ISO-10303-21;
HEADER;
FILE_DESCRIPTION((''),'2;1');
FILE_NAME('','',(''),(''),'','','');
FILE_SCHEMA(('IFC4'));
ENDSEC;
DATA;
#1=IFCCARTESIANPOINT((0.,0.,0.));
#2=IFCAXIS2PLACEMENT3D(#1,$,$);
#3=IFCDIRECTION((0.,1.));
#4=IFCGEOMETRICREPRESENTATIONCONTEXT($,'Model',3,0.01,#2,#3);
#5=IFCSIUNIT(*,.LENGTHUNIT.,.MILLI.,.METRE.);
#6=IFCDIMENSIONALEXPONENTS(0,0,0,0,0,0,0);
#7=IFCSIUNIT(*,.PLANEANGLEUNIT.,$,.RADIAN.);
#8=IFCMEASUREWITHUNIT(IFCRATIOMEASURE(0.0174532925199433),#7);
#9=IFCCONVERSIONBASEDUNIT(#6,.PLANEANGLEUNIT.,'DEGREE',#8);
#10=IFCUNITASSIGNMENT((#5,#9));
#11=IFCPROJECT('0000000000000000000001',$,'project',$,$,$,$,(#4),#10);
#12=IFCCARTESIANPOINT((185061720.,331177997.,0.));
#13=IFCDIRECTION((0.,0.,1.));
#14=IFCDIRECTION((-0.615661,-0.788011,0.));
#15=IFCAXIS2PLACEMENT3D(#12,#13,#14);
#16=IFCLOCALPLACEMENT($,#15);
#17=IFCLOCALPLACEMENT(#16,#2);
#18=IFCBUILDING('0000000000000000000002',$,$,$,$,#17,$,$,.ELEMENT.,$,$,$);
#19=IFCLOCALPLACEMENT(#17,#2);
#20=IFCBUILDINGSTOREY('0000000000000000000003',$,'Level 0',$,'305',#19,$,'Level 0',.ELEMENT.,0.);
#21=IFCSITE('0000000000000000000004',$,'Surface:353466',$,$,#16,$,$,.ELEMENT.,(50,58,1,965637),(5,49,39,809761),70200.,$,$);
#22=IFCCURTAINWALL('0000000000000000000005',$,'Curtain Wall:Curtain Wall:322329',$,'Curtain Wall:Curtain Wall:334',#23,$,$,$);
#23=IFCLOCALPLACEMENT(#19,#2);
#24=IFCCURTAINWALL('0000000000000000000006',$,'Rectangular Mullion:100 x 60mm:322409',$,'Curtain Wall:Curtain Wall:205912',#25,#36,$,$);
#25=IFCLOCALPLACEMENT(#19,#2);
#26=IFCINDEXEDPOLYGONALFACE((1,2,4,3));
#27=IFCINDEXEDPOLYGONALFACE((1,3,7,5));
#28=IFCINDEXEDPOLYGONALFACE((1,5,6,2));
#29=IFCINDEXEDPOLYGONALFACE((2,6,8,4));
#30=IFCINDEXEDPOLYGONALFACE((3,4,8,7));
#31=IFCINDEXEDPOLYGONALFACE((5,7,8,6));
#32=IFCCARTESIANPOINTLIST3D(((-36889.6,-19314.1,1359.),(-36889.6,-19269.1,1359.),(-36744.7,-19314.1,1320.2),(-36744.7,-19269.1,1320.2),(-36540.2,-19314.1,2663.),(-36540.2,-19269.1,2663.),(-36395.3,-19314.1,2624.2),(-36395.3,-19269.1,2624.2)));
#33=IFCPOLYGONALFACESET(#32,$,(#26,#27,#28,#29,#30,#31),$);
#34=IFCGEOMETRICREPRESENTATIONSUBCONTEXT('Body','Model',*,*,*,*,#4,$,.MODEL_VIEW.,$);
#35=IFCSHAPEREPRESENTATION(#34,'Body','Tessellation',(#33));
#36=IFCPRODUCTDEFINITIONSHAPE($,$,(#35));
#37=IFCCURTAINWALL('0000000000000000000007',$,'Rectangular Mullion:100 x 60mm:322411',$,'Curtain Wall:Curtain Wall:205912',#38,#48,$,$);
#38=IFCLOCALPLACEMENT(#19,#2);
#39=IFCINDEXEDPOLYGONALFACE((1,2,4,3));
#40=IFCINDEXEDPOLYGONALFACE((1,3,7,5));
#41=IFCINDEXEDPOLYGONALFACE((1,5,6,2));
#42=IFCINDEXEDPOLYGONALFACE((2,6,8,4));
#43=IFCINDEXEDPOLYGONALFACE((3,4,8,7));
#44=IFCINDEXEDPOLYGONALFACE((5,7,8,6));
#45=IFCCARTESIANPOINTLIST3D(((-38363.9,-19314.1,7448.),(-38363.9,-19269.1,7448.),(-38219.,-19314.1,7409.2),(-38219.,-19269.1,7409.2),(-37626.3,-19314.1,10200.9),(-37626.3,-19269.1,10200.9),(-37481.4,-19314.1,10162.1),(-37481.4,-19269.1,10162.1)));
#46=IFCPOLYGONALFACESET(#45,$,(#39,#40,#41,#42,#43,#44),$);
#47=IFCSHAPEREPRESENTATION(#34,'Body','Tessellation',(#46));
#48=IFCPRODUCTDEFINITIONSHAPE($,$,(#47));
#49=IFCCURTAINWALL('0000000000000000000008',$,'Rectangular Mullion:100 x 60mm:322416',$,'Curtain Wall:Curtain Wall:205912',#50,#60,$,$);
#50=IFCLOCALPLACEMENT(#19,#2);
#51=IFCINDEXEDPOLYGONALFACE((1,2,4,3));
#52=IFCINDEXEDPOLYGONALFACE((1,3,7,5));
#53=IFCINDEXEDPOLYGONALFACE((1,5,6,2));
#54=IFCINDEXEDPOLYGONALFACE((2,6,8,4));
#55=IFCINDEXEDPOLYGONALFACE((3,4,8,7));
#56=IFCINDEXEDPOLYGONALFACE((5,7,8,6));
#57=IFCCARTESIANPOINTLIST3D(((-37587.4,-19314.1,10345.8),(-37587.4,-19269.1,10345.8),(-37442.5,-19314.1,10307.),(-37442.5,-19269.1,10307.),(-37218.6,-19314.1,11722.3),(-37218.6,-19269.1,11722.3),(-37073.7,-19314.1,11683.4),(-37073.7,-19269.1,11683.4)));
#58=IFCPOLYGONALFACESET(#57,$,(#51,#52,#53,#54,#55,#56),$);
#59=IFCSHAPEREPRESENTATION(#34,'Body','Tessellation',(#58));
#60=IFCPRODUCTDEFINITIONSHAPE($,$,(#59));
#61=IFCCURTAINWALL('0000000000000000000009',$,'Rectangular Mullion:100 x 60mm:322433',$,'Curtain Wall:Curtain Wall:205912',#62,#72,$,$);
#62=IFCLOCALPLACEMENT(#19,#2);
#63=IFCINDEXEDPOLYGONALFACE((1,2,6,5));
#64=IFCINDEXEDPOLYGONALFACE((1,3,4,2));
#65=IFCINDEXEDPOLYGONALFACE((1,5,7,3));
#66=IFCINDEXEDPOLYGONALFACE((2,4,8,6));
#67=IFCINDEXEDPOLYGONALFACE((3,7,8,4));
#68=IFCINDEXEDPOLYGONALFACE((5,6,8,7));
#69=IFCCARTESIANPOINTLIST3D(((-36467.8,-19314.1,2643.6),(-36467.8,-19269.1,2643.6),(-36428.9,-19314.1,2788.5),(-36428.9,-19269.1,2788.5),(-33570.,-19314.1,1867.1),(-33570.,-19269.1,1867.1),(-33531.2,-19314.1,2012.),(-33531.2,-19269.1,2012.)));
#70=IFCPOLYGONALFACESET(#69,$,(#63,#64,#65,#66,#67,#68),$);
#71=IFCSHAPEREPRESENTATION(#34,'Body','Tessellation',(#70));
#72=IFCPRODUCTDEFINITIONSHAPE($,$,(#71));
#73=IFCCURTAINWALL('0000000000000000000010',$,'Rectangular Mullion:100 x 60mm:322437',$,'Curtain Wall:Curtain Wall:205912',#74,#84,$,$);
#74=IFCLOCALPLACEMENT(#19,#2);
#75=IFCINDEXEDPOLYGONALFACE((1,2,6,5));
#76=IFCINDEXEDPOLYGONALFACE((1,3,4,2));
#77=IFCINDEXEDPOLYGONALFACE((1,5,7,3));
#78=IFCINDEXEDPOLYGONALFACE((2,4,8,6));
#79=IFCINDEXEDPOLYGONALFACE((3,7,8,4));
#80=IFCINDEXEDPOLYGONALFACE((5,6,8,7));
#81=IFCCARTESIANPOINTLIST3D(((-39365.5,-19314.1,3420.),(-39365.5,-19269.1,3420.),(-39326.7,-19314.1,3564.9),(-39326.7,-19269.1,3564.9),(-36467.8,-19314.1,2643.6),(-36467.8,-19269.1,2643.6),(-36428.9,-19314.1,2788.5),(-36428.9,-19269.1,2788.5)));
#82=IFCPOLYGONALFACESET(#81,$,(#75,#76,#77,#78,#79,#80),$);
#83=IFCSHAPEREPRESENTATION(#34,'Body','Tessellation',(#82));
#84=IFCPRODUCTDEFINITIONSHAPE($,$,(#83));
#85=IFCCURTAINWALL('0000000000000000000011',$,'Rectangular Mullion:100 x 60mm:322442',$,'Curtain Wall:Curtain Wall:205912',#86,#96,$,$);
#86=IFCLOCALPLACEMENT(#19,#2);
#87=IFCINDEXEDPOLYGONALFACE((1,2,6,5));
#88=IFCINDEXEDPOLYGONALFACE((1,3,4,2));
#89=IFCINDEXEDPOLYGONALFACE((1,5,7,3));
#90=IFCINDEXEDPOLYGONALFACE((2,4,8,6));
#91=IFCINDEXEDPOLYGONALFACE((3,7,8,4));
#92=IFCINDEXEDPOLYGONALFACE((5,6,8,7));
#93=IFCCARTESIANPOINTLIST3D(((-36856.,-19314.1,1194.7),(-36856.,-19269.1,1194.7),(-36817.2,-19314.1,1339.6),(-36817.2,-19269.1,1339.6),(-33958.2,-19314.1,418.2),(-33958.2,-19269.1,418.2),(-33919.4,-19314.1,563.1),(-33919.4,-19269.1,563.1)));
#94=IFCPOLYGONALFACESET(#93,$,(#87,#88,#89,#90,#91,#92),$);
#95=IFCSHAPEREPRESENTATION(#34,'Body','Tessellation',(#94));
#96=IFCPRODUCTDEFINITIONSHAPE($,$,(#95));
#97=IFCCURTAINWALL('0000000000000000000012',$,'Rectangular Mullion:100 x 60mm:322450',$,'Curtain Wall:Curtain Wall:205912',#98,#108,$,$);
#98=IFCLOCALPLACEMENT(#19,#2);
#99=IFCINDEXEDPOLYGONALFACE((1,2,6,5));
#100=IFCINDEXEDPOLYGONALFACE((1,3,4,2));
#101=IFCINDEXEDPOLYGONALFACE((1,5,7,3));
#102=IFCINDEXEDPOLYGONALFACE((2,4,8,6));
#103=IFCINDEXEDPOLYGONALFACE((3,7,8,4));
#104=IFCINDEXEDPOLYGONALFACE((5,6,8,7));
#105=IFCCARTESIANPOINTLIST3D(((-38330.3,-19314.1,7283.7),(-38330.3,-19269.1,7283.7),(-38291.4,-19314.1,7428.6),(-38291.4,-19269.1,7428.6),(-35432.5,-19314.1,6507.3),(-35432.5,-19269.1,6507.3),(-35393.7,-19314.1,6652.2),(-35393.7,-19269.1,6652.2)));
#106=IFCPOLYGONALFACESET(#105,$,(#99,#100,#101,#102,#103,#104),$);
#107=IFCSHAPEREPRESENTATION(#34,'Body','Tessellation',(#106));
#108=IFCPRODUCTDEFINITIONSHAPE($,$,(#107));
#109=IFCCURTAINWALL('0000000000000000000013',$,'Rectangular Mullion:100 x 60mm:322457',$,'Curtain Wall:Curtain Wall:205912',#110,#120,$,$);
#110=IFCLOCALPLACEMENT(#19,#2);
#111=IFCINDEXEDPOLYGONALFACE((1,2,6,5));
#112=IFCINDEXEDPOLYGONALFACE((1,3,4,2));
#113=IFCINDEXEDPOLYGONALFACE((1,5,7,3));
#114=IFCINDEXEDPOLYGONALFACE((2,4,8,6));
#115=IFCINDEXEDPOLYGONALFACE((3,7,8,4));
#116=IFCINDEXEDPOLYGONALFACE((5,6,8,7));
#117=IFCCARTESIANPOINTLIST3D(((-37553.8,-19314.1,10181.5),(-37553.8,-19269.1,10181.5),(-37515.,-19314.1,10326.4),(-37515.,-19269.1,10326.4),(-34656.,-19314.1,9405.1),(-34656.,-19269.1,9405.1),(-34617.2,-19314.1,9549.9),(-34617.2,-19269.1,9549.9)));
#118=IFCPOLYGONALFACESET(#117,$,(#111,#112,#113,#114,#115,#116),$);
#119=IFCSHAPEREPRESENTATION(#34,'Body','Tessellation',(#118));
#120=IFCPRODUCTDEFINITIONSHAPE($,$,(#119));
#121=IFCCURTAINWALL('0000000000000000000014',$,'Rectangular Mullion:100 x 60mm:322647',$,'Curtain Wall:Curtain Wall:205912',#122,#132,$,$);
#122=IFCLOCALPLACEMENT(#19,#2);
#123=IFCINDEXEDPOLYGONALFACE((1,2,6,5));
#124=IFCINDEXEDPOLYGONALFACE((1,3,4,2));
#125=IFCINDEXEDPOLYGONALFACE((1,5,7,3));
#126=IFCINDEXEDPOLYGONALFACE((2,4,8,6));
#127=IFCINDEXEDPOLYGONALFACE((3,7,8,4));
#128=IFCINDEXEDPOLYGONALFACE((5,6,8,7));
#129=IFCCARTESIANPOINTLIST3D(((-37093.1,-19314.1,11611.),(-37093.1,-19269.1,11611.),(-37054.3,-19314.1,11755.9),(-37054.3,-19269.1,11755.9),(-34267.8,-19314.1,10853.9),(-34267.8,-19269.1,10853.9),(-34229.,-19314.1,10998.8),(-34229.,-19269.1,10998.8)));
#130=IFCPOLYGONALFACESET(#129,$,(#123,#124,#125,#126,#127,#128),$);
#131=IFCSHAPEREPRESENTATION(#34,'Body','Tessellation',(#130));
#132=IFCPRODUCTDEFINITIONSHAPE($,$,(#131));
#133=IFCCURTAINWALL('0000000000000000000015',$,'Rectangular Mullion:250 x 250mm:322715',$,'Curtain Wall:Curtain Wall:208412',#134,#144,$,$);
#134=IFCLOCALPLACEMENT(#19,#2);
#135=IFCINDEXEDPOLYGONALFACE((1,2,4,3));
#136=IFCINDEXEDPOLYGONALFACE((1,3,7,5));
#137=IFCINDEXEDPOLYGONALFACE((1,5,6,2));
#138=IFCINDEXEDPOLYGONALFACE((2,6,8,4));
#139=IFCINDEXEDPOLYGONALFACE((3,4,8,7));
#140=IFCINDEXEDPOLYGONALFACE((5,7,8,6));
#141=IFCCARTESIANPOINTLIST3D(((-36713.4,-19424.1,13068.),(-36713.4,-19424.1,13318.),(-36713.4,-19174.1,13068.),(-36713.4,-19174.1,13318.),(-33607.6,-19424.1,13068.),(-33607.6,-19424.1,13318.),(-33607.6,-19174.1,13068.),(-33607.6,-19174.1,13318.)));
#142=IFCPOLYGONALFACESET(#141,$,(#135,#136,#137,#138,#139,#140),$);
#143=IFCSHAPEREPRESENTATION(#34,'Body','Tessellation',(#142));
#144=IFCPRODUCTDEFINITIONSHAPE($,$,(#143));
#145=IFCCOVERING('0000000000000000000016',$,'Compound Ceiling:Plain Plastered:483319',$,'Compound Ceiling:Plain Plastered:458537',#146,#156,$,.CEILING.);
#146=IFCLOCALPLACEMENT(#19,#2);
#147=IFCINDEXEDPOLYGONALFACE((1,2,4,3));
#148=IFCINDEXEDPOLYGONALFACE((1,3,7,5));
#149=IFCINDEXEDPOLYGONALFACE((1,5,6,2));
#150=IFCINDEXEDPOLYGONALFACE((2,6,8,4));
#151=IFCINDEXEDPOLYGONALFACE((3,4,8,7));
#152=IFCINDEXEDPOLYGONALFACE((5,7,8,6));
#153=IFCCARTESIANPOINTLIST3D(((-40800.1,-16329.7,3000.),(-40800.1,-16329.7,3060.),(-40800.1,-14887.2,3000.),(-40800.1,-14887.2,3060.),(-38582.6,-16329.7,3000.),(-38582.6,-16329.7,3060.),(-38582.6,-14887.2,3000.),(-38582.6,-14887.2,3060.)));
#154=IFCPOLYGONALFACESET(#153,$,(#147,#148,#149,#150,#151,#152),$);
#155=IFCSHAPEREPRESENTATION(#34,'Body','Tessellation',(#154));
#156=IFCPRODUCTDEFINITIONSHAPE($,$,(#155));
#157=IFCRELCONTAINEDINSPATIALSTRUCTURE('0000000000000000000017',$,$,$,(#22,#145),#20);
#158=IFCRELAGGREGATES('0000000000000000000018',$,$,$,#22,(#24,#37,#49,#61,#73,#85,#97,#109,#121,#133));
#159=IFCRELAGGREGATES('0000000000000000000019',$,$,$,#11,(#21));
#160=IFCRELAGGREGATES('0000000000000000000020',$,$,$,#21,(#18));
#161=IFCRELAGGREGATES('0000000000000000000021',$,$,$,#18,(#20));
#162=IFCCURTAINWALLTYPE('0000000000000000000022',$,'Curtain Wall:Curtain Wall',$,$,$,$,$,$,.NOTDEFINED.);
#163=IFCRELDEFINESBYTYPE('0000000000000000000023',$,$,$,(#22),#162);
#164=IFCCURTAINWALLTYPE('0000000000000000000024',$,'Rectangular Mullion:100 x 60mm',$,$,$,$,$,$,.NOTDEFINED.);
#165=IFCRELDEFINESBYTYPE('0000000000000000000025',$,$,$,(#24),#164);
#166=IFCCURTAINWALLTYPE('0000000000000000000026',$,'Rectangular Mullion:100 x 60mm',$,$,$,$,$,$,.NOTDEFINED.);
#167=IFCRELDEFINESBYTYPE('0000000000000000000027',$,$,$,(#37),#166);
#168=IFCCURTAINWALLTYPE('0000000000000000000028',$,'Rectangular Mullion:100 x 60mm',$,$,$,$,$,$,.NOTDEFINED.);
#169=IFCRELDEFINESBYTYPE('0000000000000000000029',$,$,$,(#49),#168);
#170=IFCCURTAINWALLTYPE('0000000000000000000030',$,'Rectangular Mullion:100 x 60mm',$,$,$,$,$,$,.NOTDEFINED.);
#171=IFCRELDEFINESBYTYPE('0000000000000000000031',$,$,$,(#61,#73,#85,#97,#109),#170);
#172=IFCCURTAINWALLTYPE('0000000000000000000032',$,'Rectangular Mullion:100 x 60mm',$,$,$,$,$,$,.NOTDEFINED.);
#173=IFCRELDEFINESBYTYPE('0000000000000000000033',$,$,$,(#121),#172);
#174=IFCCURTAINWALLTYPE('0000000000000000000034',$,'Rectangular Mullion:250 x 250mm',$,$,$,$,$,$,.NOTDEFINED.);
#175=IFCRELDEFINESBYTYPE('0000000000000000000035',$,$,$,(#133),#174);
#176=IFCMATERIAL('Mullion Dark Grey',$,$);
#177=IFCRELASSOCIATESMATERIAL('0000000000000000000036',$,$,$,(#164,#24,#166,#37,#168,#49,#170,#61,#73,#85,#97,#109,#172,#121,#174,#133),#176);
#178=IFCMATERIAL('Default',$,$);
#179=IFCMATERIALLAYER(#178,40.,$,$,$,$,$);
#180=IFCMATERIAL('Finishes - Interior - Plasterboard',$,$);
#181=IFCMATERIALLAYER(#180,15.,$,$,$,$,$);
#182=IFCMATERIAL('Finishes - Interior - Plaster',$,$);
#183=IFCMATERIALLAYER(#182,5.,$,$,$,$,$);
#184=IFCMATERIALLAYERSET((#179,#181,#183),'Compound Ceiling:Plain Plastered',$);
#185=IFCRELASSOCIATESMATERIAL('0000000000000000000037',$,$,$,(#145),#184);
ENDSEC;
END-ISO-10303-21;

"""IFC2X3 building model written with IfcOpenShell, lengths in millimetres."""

from ifc_helpers import new_model, entity, si_unit, converted_unit, direction, frame, frame_2d, origin, origin_2d_with_axis, place, context, subcontext, project, spatial, rectangle, extrude, source, transform, mapped, material, layer, layer_set, layer_usage, type_object, type_shapes, element, aggregate, save


model = new_model("IFC2X3")

# Units and contexts
model_context = context("Model", 3, precision=0.01, world=origin(), true_north=direction((0.0, 1.0)))
body_context = subcontext(model_context, "Body", "Model", "MODEL_VIEW")
ifc_project = project(units=[si_unit("LENGTHUNIT", "METRE", prefix="MILLI"), converted_unit("PLANEANGLEUNIT", "DEGREE", entity("IfcRatioMeasure", 0.0174532925199433), si_unit("PLANEANGLEUNIT", "RADIAN"), dimensions=[0, 0, 0, 0, 0, 0, 0])], contexts=[model_context])

# Site, building, storey
site_placement = place(None, frame((185061720.0, 331177997.0, 0.0), z_axis=(0.0, 0.0, 1.0), x_axis=(-0.615661, -0.788011, 0.0)))
site = spatial("IfcSite", under=ifc_project, at=site_placement, Name="Surface:353466", CompositionType="ELEMENT", RefLatitude=(50, 58, 1, 965637), RefLongitude=(5, 49, 39, 809761), RefElevation=70200.0)
building_placement = place(site_placement, origin())
building = spatial("IfcBuilding", under=site, at=building_placement, CompositionType="ELEMENT")
storey_placement = place(building_placement, origin())
storey = spatial("IfcBuildingStorey", under=building, at=storey_placement, Name="Level 0", ObjectType="305", LongName="Level 0", CompositionType="ELEMENT", Elevation=0.0)

# Shared definitions
ifc_material_1 = material(Name="Finishes - Interior - Plasterboard")

# Curtain walls
curtain_wall_type_1 = type_object("IfcCurtainWallType", Name="Curtain Wall:Curtain Wall", PredefinedType="NOTDEFINED")
curtain_wall_1_placement = place(storey_placement, origin())
curtain_wall_1 = element("IfcCurtainWall", 1, at=curtain_wall_1_placement, inside=storey, type_object=curtain_wall_type_1, Name="Curtain Wall:Curtain Wall:322329", ObjectType="Curtain Wall:Curtain Wall:334")
ifc_material_2 = material(Name="Mullion Dark Grey")
curtain_wall_type_2 = type_object("IfcCurtainWallType", Name="Rectangular Mullion:100 x 60mm", PredefinedType="NOTDEFINED", material=ifc_material_2)
shared_shape_1 = source(origin(), body_context, "Body", "SweptSolid", [
    extrude(rectangle(XDim=45.0, YDim=150.0, at=frame_2d((0.0, 0.0), x_axis=(1.0, 0.0))), frame((0.0, 7.5, -1350.0), z_axis=(0.0, 0.0, 1.0), x_axis=(0.0, -1.0, 0.0)), (0.0, 0.0, 1.0), 1350.0),
])
type_shapes(curtain_wall_type_2, [shared_shape_1])
curtain_wall_2_placement = place(storey_placement, frame((-36817.2, -19299.1, 1339.6), z_axis=(-0.258819, 0.0, -0.965926), x_axis=(-0.965926, 0.0, 0.258819)))
curtain_wall_2 = element("IfcCurtainWall", 2, at=curtain_wall_2_placement, type_object=curtain_wall_type_2, material=ifc_material_2, Name="Rectangular Mullion:100 x 60mm:322409", ObjectType="Curtain Wall:Curtain Wall:205912", context=body_context, shape_type="MappedRepresentation", body=[
    mapped(shared_shape_1, transform((0.0, 0.0, 0.0), scale=1.0)),
])
curtain_wall_type_3 = type_object("IfcCurtainWallType", Name="Rectangular Mullion:100 x 60mm", PredefinedType="NOTDEFINED", material=ifc_material_2)
shared_shape_2 = source(origin(), body_context, "Body", "SweptSolid", [
    extrude(rectangle(XDim=45.0, YDim=150.0, at=frame_2d((0.0, 0.0), x_axis=(1.0, 0.0))), frame((0.0, 7.5, -2850.0), z_axis=(0.0, 0.0, 1.0), x_axis=(0.0, -1.0, 0.0)), (0.0, 0.0, 1.0), 2850.0),
])
type_shapes(curtain_wall_type_3, [shared_shape_2])
curtain_wall_3_placement = place(storey_placement, frame((-38291.4, -19299.1, 7428.6), z_axis=(-0.258819, 0.0, -0.965926), x_axis=(-0.965926, 0.0, 0.258819)))
curtain_wall_3 = element("IfcCurtainWall", 3, at=curtain_wall_3_placement, type_object=curtain_wall_type_3, material=ifc_material_2, Name="Rectangular Mullion:100 x 60mm:322411", ObjectType="Curtain Wall:Curtain Wall:205912", context=body_context, shape_type="MappedRepresentation", body=[
    mapped(shared_shape_2, transform((0.0, 0.0, 0.0), scale=1.0)),
])
curtain_wall_type_4 = type_object("IfcCurtainWallType", Name="Rectangular Mullion:100 x 60mm", PredefinedType="NOTDEFINED", material=ifc_material_2)
shared_shape_3 = source(origin(), body_context, "Body", "SweptSolid", [
    extrude(rectangle(XDim=45.0, YDim=150.0, at=frame_2d((0.0, 0.0), x_axis=(1.0, 0.0))), frame((0.0, 7.5, -1425.0), z_axis=(0.0, 0.0, 1.0), x_axis=(0.0, -1.0, 0.0)), (0.0, 0.0, 1.0), 1425.0),
])
type_shapes(curtain_wall_type_4, [shared_shape_3])
curtain_wall_4_placement = place(storey_placement, frame((-37515.0, -19299.1, 10326.4), z_axis=(-0.258819, 0.0, -0.965926), x_axis=(-0.965926, 0.0, 0.258819)))
curtain_wall_4 = element("IfcCurtainWall", 4, at=curtain_wall_4_placement, type_object=curtain_wall_type_4, material=ifc_material_2, Name="Rectangular Mullion:100 x 60mm:322416", ObjectType="Curtain Wall:Curtain Wall:205912", context=body_context, shape_type="MappedRepresentation", body=[
    mapped(shared_shape_3, transform((0.0, 0.0, 0.0), scale=1.0)),
])
curtain_wall_type_5 = type_object("IfcCurtainWallType", Name="Rectangular Mullion:100 x 60mm", PredefinedType="NOTDEFINED", material=ifc_material_2)
shared_shape_4 = source(origin(), body_context, "Body", "SweptSolid", [
    extrude(rectangle(XDim=45.0, YDim=150.0, at=frame_2d((0.0, 0.0), x_axis=(1.0, 0.0))), frame((0.0, 7.5, -3000.0), z_axis=(0.0, 0.0, 1.0), x_axis=(0.0, -1.0, 0.0)), (0.0, 0.0, 1.0), 3000.0),
])
type_shapes(curtain_wall_type_5, [shared_shape_4])
curtain_wall_5_placement = place(storey_placement, frame((-36448.4, -19299.1, 2716.0), z_axis=(-0.965926, 0.0, 0.258819), x_axis=(0.258819, 0.0, 0.965926)))
curtain_wall_5 = element("IfcCurtainWall", 5, at=curtain_wall_5_placement, type_object=curtain_wall_type_5, material=ifc_material_2, Name="Rectangular Mullion:100 x 60mm:322433", ObjectType="Curtain Wall:Curtain Wall:205912", context=body_context, shape_type="MappedRepresentation", body=[
    mapped(shared_shape_4, transform((0.0, 0.0, 0.0), scale=1.0)),
])
curtain_wall_6_placement = place(storey_placement, frame((-39346.1, -19299.1, 3492.5), z_axis=(-0.965926, 0.0, 0.258819), x_axis=(0.258819, 0.0, 0.965926)))
curtain_wall_6 = element("IfcCurtainWall", 6, at=curtain_wall_6_placement, type_object=curtain_wall_type_5, material=ifc_material_2, Name="Rectangular Mullion:100 x 60mm:322437", ObjectType="Curtain Wall:Curtain Wall:205912", context=body_context, shape_type="MappedRepresentation", body=[
    mapped(shared_shape_4, transform((0.0, 0.0, 0.0), scale=1.0)),
])
curtain_wall_7_placement = place(storey_placement, frame((-36836.6, -19299.1, 1267.1), z_axis=(-0.965926, 0.0, 0.258819), x_axis=(0.258819, 0.0, 0.965926)))
curtain_wall_7 = element("IfcCurtainWall", 7, at=curtain_wall_7_placement, type_object=curtain_wall_type_5, material=ifc_material_2, Name="Rectangular Mullion:100 x 60mm:322442", ObjectType="Curtain Wall:Curtain Wall:205912", context=body_context, shape_type="MappedRepresentation", body=[
    mapped(shared_shape_4, transform((0.0, 0.0, 0.0), scale=1.0)),
])
curtain_wall_8_placement = place(storey_placement, frame((-38310.9, -19299.1, 7356.2), z_axis=(-0.965926, 0.0, 0.258819), x_axis=(0.258819, 0.0, 0.965926)))
curtain_wall_8 = element("IfcCurtainWall", 8, at=curtain_wall_8_placement, type_object=curtain_wall_type_5, material=ifc_material_2, Name="Rectangular Mullion:100 x 60mm:322450", ObjectType="Curtain Wall:Curtain Wall:205912", context=body_context, shape_type="MappedRepresentation", body=[
    mapped(shared_shape_4, transform((0.0, 0.0, 0.0), scale=1.0)),
])
curtain_wall_9_placement = place(storey_placement, frame((-37534.4, -19299.1, 10254.0), z_axis=(-0.965926, 0.0, 0.258819), x_axis=(0.258819, 0.0, 0.965926)))
curtain_wall_9 = element("IfcCurtainWall", 9, at=curtain_wall_9_placement, type_object=curtain_wall_type_5, material=ifc_material_2, Name="Rectangular Mullion:100 x 60mm:322457", ObjectType="Curtain Wall:Curtain Wall:205912", context=body_context, shape_type="MappedRepresentation", body=[
    mapped(shared_shape_4, transform((0.0, 0.0, 0.0), scale=1.0)),
])
curtain_wall_type_6 = type_object("IfcCurtainWallType", Name="Rectangular Mullion:100 x 60mm", PredefinedType="NOTDEFINED", material=ifc_material_2)
shared_shape_5 = source(origin(), body_context, "Body", "SweptSolid", [
    extrude(rectangle(XDim=45.0, YDim=150.0, at=frame_2d((0.0, 0.0), x_axis=(1.0, 0.0))), frame((0.0, 7.5, -2925.0), z_axis=(0.0, 0.0, 1.0), x_axis=(0.0, -1.0, 0.0)), (0.0, 0.0, 1.0), 2925.0),
])
type_shapes(curtain_wall_type_6, [shared_shape_5])
curtain_wall_10_placement = place(storey_placement, frame((-37073.7, -19299.1, 11683.4), z_axis=(-0.965926, 0.0, 0.258819), x_axis=(0.258819, 0.0, 0.965926)))
curtain_wall_10 = element("IfcCurtainWall", 10, at=curtain_wall_10_placement, type_object=curtain_wall_type_6, material=ifc_material_2, Name="Rectangular Mullion:100 x 60mm:322647", ObjectType="Curtain Wall:Curtain Wall:205912", context=body_context, shape_type="MappedRepresentation", body=[
    mapped(shared_shape_5, transform((0.0, 0.0, 0.0), scale=1.0)),
])
curtain_wall_type_7 = type_object("IfcCurtainWallType", Name="Rectangular Mullion:250 x 250mm", PredefinedType="NOTDEFINED", material=ifc_material_2)
shared_shape_6 = source(origin(), body_context, "Body", "SweptSolid", [
    extrude(rectangle(XDim=250.0, YDim=250.0, at=origin_2d_with_axis()), frame((-125.0, 0.0, -3105.8), z_axis=(0.0, 0.0, 1.0), x_axis=(-1.0, 0.0, 0.0)), (0.0, 0.0, 1.0), 3105.8),
])
type_shapes(curtain_wall_type_7, [shared_shape_6])
curtain_wall_11_placement = place(storey_placement, frame((-36713.4, -19299.1, 13318.0), z_axis=(-1.0, 0.0, 0.0), x_axis=(0.0, 0.0, 1.0)))
curtain_wall_11 = element("IfcCurtainWall", 11, at=curtain_wall_11_placement, type_object=curtain_wall_type_7, material=ifc_material_2, Name="Rectangular Mullion:250 x 250mm:322715", ObjectType="Curtain Wall:Curtain Wall:208412", context=body_context, shape_type="MappedRepresentation", body=[
    mapped(shared_shape_6, transform((0.0, 0.0, 0.0), scale=1.0)),
])
aggregate(curtain_wall_1, [curtain_wall_2, curtain_wall_3, curtain_wall_4, curtain_wall_5, curtain_wall_6, curtain_wall_7, curtain_wall_8, curtain_wall_9, curtain_wall_10, curtain_wall_11])

# Covering
ifc_material_3 = material(Name="Default")
ifc_layer_1 = layer(ifc_material_3, 40.0)
ifc_layer_2 = layer(ifc_material_1, 15.0)
ifc_material_4 = material(Name="Finishes - Interior - Plaster")
ifc_layer_3 = layer(ifc_material_4, 5.0)
ifc_layer_set_1 = layer_set([ifc_layer_1, ifc_layer_2, ifc_layer_3], Name="Compound Ceiling:Plain Plastered")
ifc_layer_usage_1 = layer_usage(ifc_layer_set_1, "AXIS3", "POSITIVE", 0.0)
covering_placement = place(storey_placement, frame((-40800.1, -16329.7, 3000.0)))
element("IfcCovering", 12, at=covering_placement, inside=storey, material=ifc_layer_usage_1, Name="Compound Ceiling:Plain Plastered:483319", ObjectType="Compound Ceiling:Plain Plastered:458537", PredefinedType="CEILING", context=body_context, shape_type="SweptSolid", body=[
    extrude(rectangle(XDim=2217.5, YDim=1442.5, at=frame_2d((0.0, 0.0), x_axis=(1.0, 0.0))), frame((1108.8, 721.3, 0.0), z_axis=(0.0, 0.0, 1.0), x_axis=(-1.0, 0.0, 0.0)), (0.0, 0.0, 1.0), 60.0),
])

save(model, "model.ifc")
